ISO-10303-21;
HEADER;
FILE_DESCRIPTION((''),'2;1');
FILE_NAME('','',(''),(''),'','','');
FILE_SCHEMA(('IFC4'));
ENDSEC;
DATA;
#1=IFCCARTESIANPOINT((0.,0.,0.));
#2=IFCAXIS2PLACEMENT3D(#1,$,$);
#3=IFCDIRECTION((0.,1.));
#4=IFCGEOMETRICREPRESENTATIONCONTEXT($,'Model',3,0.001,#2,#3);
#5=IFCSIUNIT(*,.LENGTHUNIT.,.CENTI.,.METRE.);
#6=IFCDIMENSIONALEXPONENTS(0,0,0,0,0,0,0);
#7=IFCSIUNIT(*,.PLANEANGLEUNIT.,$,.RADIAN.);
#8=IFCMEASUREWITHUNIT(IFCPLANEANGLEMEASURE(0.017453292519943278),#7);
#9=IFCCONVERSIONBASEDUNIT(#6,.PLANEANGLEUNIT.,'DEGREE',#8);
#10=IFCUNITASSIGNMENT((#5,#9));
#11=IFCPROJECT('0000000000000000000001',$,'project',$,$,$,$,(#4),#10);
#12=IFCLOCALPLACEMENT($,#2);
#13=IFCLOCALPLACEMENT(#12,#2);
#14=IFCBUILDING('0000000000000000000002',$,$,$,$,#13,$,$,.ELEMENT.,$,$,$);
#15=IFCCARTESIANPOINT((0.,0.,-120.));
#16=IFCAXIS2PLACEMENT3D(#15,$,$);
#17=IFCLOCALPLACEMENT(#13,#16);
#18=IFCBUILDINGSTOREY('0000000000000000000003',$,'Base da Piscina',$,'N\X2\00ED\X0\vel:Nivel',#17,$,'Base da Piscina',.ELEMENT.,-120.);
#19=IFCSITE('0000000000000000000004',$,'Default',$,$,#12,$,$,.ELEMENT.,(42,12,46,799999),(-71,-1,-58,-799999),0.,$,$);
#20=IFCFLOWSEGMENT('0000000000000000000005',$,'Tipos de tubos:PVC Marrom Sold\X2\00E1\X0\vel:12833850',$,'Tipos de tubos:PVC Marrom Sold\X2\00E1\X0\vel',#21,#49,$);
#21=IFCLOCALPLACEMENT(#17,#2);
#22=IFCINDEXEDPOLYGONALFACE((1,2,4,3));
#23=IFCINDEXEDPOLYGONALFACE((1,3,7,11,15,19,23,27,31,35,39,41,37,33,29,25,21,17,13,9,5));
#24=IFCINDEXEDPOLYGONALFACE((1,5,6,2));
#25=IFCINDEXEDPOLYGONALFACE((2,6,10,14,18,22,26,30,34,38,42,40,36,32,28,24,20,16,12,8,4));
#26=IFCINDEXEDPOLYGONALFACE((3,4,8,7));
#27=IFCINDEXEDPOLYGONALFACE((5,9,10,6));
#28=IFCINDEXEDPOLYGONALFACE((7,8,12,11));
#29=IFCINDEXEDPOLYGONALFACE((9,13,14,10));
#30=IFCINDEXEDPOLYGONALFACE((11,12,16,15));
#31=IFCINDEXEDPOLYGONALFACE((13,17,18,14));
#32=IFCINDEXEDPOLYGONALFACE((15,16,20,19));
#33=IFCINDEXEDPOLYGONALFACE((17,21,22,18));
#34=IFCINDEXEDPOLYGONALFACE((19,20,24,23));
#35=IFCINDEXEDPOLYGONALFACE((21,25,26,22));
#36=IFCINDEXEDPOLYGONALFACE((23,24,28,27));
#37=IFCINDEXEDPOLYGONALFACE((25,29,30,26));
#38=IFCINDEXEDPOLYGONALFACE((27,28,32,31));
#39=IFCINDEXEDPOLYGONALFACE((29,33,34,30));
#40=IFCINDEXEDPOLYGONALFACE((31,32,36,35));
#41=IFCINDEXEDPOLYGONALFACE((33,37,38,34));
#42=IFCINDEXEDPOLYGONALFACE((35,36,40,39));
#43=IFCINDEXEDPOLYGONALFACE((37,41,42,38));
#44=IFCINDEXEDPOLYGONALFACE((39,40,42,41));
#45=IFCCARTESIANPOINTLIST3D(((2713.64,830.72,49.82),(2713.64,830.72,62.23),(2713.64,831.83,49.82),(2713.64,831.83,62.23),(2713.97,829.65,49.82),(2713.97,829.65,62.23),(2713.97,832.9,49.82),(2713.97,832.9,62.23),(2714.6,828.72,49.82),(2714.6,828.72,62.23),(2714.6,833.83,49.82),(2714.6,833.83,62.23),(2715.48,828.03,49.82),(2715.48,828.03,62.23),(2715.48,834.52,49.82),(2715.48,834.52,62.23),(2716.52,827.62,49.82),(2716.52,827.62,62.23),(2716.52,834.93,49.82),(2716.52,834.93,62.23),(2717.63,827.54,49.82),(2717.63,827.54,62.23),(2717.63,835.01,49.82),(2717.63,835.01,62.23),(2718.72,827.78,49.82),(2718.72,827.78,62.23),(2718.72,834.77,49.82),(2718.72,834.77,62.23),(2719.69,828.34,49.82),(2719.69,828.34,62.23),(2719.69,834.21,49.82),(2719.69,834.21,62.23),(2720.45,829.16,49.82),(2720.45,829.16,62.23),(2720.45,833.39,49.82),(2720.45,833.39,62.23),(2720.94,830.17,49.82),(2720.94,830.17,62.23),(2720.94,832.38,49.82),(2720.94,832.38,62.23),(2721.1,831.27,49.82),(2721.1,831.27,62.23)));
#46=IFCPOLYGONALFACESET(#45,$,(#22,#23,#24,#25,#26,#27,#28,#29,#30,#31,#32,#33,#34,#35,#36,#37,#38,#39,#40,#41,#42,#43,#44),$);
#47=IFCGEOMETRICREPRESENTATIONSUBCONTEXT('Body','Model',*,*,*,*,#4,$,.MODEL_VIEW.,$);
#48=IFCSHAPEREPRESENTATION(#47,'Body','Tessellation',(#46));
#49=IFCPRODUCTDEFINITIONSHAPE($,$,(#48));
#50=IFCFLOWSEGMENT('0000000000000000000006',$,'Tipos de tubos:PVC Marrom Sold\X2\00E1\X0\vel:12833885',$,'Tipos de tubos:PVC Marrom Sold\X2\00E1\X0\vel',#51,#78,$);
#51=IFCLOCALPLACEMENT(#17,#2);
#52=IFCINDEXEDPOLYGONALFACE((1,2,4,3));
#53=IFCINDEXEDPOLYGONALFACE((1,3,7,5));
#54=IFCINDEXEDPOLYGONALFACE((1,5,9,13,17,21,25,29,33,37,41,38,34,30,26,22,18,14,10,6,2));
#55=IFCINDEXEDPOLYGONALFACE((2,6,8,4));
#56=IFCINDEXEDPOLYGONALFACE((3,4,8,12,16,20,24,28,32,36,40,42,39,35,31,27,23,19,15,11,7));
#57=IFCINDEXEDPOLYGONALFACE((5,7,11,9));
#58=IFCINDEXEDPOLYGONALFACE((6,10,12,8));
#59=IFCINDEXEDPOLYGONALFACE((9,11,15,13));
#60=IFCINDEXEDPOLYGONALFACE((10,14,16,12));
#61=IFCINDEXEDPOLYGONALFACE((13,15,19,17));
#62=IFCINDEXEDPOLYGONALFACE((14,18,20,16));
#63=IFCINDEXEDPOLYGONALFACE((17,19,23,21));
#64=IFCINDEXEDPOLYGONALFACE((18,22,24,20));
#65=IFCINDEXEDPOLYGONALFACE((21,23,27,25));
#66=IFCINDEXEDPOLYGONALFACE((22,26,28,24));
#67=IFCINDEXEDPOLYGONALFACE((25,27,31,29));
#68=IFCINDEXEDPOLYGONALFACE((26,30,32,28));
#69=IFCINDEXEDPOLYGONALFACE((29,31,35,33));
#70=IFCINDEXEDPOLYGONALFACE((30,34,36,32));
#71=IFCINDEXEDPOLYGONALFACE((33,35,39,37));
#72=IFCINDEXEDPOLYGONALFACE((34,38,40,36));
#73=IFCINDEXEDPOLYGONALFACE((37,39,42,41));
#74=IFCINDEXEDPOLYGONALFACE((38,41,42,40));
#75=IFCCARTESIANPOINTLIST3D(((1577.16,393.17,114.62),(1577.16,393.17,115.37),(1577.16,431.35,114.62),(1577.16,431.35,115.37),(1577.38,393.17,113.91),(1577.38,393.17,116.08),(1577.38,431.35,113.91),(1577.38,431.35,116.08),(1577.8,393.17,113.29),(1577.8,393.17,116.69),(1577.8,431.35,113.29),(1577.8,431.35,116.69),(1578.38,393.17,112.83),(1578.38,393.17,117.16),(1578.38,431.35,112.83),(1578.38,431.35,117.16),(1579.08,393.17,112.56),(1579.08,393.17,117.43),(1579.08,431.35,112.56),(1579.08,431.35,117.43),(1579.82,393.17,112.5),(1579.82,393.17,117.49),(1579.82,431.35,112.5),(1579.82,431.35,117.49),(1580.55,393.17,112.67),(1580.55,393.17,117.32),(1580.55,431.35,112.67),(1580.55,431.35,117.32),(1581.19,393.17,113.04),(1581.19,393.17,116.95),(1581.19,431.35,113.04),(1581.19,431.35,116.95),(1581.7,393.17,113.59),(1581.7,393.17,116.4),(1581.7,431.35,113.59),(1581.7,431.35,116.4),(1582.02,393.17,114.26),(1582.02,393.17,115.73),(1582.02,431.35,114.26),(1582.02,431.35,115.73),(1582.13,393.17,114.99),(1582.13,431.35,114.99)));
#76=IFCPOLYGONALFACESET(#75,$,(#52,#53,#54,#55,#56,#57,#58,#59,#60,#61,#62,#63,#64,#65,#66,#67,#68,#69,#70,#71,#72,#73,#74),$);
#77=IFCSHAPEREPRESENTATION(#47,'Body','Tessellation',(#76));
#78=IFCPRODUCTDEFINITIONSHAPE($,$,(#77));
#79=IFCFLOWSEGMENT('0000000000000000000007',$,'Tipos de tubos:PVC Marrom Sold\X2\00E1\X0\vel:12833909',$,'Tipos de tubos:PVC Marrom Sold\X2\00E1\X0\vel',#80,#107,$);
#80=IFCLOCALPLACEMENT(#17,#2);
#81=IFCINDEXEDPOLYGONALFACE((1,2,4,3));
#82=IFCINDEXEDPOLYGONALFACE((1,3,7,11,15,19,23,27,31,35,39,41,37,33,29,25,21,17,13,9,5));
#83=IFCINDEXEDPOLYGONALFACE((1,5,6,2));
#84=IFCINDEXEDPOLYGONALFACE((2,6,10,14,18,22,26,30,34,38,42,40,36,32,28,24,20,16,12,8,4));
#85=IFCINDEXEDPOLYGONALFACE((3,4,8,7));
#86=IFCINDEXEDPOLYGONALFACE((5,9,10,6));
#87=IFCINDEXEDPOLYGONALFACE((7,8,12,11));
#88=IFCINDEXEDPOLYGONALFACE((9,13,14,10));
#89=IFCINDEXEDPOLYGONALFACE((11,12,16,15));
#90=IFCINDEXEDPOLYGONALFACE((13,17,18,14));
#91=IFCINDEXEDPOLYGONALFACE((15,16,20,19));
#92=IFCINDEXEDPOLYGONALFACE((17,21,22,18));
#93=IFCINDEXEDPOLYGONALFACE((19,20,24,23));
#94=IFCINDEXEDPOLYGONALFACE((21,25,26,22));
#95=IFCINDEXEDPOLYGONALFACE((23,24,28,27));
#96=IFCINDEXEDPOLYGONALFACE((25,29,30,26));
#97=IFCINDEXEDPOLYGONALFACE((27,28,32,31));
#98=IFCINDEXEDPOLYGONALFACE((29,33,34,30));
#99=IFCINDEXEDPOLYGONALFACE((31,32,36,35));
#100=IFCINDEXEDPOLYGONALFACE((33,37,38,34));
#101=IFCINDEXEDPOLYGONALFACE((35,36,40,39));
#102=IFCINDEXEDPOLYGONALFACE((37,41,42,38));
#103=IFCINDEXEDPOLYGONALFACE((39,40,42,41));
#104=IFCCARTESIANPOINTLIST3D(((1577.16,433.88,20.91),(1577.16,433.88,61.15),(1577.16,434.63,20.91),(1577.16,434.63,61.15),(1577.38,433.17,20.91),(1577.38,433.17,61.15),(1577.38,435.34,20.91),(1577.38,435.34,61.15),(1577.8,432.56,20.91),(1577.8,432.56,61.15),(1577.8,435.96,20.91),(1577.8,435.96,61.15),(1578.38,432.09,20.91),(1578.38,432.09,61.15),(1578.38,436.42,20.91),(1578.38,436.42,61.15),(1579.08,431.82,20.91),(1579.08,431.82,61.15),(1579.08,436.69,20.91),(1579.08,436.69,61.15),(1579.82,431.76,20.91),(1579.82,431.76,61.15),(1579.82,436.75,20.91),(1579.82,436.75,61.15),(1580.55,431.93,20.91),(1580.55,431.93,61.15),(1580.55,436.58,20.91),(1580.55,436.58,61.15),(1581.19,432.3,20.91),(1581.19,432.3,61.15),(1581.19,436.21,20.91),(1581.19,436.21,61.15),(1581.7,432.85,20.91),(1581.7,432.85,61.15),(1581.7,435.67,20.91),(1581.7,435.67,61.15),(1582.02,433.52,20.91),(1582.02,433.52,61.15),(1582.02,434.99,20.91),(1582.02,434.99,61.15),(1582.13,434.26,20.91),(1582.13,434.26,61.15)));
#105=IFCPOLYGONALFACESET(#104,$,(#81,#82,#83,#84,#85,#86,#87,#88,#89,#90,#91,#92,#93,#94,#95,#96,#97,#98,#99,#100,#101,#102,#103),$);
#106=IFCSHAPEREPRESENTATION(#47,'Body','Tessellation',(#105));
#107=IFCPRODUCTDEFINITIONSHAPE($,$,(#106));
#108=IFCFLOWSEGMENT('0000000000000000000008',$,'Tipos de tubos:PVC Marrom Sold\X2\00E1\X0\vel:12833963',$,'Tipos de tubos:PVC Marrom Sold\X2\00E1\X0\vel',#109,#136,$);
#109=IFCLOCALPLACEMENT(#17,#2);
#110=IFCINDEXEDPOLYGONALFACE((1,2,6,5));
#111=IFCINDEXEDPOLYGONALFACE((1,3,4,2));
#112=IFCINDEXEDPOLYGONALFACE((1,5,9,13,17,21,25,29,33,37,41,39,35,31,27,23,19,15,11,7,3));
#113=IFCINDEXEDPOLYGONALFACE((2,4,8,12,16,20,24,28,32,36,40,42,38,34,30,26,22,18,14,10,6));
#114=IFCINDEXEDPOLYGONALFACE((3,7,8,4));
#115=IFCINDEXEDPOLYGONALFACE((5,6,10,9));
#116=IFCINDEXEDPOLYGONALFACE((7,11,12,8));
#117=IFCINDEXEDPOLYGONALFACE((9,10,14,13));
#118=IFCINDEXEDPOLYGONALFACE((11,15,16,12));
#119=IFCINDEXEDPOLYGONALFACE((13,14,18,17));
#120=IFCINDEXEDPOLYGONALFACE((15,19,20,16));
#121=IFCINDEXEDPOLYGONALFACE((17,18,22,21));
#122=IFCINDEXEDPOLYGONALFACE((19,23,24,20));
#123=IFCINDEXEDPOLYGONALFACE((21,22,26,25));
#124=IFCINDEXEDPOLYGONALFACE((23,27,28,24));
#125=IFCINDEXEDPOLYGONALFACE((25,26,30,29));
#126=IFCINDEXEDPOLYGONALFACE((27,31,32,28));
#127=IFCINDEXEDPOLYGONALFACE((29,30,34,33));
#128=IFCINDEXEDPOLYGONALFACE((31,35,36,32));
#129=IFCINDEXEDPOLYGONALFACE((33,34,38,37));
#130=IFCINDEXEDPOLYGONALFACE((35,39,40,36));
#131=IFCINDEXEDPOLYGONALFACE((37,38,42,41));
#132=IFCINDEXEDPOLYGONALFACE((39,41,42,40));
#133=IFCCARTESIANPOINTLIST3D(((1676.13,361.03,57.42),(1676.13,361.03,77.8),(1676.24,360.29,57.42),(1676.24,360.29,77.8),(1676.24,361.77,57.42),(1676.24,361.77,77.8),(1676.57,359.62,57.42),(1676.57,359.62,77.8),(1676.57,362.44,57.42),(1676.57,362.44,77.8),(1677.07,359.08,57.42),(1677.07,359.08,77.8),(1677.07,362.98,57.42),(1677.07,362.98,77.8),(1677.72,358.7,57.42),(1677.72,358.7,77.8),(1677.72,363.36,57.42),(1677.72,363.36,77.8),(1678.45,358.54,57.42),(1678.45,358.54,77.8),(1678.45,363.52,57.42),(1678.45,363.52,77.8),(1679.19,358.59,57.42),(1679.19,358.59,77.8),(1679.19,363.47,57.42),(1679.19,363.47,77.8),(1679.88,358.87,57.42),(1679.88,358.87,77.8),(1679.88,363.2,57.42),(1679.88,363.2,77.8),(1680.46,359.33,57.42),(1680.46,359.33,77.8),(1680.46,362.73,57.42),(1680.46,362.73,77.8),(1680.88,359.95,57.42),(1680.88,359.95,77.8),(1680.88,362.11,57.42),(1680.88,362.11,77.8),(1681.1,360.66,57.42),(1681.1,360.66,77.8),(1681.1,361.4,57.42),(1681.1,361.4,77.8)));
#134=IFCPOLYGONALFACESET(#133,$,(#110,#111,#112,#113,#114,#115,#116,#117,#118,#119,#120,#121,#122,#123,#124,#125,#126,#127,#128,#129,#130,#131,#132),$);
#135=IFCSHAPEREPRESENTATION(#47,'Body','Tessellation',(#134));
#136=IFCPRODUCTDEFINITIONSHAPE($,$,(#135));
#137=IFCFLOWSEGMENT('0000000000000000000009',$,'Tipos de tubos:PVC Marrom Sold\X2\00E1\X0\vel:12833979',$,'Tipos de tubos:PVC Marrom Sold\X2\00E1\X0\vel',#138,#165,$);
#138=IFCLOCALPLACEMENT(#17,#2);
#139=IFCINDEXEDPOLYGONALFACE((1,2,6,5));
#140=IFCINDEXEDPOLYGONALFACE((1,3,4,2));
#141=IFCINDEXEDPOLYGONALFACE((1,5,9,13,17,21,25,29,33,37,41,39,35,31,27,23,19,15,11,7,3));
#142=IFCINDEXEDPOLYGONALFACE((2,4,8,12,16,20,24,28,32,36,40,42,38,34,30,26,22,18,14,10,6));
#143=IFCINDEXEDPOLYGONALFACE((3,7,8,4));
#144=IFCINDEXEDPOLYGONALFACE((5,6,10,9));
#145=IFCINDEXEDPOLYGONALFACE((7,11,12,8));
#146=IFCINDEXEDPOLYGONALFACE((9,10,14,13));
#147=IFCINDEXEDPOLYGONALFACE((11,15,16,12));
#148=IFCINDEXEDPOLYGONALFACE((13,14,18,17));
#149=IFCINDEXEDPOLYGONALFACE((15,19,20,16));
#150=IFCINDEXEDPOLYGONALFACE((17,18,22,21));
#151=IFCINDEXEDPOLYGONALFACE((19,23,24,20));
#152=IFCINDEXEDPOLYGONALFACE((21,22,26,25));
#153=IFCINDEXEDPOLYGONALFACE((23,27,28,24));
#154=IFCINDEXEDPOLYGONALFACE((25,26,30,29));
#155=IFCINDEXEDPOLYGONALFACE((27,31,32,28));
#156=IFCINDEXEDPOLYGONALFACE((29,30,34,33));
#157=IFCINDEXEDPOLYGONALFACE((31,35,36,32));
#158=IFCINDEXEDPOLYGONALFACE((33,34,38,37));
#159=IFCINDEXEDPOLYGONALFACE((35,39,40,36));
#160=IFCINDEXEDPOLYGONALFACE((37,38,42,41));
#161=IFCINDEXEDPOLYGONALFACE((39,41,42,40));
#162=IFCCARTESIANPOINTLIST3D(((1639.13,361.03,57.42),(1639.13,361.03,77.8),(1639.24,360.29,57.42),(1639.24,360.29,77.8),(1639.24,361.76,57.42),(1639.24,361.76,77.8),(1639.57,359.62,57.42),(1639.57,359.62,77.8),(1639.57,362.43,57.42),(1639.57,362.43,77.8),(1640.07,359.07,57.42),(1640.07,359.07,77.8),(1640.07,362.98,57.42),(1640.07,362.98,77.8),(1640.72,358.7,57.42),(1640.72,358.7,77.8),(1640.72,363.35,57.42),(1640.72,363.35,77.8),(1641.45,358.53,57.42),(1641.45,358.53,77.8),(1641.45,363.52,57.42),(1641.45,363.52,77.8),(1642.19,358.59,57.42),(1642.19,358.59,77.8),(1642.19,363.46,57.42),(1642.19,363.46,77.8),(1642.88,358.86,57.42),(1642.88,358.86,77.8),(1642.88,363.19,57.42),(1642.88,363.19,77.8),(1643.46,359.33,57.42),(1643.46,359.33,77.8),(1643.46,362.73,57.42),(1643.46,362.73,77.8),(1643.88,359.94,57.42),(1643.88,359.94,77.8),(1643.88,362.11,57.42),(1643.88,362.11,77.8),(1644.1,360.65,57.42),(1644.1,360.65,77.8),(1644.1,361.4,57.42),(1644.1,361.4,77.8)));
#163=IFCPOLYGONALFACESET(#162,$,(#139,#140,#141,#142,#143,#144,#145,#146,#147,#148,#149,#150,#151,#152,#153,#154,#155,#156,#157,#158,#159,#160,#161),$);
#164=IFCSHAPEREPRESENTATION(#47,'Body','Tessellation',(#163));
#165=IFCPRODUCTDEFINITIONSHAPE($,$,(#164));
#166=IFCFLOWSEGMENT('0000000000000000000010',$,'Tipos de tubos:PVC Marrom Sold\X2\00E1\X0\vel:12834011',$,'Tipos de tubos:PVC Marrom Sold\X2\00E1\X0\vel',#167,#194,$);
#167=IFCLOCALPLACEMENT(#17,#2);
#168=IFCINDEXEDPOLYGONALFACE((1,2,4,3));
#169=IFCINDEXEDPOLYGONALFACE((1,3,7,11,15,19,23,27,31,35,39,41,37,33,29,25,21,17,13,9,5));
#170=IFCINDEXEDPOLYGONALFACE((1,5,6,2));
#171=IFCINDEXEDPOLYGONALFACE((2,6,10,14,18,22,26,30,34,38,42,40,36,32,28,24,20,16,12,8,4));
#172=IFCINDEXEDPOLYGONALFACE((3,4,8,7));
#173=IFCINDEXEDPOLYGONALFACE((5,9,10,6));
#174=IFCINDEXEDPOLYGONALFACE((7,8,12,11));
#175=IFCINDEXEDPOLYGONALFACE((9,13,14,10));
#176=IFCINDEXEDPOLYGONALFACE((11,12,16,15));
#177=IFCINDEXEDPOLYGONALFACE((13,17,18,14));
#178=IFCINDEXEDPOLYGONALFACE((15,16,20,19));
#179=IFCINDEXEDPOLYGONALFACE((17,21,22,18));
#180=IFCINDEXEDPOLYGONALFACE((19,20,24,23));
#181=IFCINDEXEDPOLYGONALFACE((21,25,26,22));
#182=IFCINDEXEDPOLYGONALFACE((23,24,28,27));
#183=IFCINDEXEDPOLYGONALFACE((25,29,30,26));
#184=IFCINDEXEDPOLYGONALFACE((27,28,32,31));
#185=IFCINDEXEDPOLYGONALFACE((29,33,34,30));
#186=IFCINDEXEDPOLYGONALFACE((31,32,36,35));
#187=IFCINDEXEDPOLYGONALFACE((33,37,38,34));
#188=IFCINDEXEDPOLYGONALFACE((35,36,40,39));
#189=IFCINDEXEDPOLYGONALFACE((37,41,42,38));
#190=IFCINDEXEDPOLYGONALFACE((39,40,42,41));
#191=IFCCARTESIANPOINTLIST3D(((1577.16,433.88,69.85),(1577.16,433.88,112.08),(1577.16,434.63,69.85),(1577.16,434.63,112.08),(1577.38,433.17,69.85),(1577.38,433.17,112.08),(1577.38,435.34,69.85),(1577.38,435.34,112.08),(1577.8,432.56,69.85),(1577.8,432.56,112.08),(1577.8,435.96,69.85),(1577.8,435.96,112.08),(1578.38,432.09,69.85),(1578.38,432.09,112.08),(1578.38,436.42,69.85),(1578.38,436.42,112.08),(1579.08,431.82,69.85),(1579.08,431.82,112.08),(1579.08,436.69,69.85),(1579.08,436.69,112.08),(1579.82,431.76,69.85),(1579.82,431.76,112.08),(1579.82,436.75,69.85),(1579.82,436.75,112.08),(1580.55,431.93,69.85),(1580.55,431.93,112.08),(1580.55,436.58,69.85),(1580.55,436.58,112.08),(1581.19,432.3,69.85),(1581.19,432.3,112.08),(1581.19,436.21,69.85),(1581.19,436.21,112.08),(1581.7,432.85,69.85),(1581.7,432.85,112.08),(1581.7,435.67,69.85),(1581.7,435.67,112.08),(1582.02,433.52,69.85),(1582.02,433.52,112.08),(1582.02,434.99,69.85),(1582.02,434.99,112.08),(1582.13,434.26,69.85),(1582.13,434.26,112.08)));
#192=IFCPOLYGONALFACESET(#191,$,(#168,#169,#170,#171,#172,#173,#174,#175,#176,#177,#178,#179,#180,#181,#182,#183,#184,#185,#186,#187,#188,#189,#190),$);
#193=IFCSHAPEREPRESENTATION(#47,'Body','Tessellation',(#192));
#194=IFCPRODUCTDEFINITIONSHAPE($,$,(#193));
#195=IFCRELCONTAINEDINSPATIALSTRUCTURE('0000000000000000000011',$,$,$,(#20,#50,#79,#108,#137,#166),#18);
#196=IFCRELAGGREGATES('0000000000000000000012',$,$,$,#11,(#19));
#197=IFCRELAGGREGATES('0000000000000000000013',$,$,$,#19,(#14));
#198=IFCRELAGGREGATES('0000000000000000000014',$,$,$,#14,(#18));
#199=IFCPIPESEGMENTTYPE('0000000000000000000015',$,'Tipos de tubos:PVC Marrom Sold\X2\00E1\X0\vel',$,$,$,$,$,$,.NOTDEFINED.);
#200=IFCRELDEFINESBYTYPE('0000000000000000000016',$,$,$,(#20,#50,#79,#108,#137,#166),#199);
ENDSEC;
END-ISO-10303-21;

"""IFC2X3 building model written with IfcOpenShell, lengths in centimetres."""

from ifc_helpers import new_model, entity, si_unit, converted_unit, direction, frame, frame_2d, origin, origin_2d_with_axis, place, context, subcontext, project, spatial, circle, extrude, type_object, element, save


model = new_model("IFC2X3")

# Units and contexts
model_context = context("Model", 3, precision=0.001, world=origin(), true_north=direction((0.0, 1.0)))
body_context = subcontext(model_context, "Body", "Model", "MODEL_VIEW")
ifc_project = project(units=[si_unit("LENGTHUNIT", "METRE", prefix="CENTI"), converted_unit("PLANEANGLEUNIT", "DEGREE", entity("IfcPlaneAngleMeasure", 0.017453292519943278), si_unit("PLANEANGLEUNIT", "RADIAN"), dimensions=[0, 0, 0, 0, 0, 0, 0])], contexts=[model_context])

# Site, building, storey
site_placement = place(None, origin())
site = spatial("IfcSite", under=ifc_project, at=site_placement, Name="Default", CompositionType="ELEMENT", RefLatitude=(42, 12, 46, 799999), RefLongitude=(-71, -1, -58, -799999), RefElevation=0.0)
building_placement = place(site_placement, origin())
building = spatial("IfcBuilding", under=site, at=building_placement, CompositionType="ELEMENT")
storey_placement = place(building_placement, frame((0.0, 0.0, -120.0)))
storey = spatial("IfcBuildingStorey", under=building, at=storey_placement, Name="Base da Piscina", ObjectType="Nível:Nivel", LongName="Base da Piscina", CompositionType="ELEMENT", Elevation=-120.0)

# Flow segments
pipe_segment_type = type_object("IfcPipeSegmentType", Name="Tipos de tubos:PVC Marrom Soldável", PredefinedType="NOTDEFINED")
flow_segment_1_placement = place(storey_placement, origin())
element("IfcFlowSegment", 1, at=flow_segment_1_placement, inside=storey, type_object=pipe_segment_type, Name="Tipos de tubos:PVC Marrom Soldável:12833850", ObjectType="Tipos de tubos:PVC Marrom Soldável", context=body_context, shape_type="SweptSolid", body=[
    extrude(circle(Radius=3.75, at=origin_2d_with_axis()), frame((2717.35, 831.27, 49.82)), (0.0, 0.0, 1.0), 12.41),
])
flow_segment_2_placement = place(storey_placement, origin())
element("IfcFlowSegment", 2, at=flow_segment_2_placement, inside=storey, type_object=pipe_segment_type, Name="Tipos de tubos:PVC Marrom Soldável:12833885", ObjectType="Tipos de tubos:PVC Marrom Soldável", context=body_context, shape_type="SweptSolid", body=[
    extrude(circle(Radius=2.5, at=frame_2d((0.0, 0.0), x_axis=(1.0, 0.0))), frame((1579.63, 393.17, 114.99), z_axis=(0.0, 1.0, 0.0), x_axis=(1.0, 0.0, 0.0)), (0.0, 0.0, 1.0), 38.17),
])
flow_segment_3_placement = place(storey_placement, origin())
element("IfcFlowSegment", 3, at=flow_segment_3_placement, inside=storey, type_object=pipe_segment_type, Name="Tipos de tubos:PVC Marrom Soldável:12833909", ObjectType="Tipos de tubos:PVC Marrom Soldável", context=body_context, shape_type="SweptSolid", body=[
    extrude(circle(Radius=2.5, at=frame_2d((0.0, 0.0), x_axis=(1.0, 0.0))), frame((1579.63, 434.26, 20.91)), (0.0, 0.0, 1.0), 40.24),
])
flow_segment_4_placement = place(storey_placement, origin())
element("IfcFlowSegment", 4, at=flow_segment_4_placement, inside=storey, type_object=pipe_segment_type, Name="Tipos de tubos:PVC Marrom Soldável:12833963", ObjectType="Tipos de tubos:PVC Marrom Soldável", context=body_context, shape_type="SweptSolid", body=[
    extrude(circle(Radius=2.5, at=frame_2d((0.0, 0.0), x_axis=(1.0, 0.0))), frame((1678.63, 361.03, 57.42), z_axis=(0.0, 0.0, 1.0), x_axis=(-1.0, 0.0, 0.0)), (0.0, 0.0, 1.0), 20.38),
])
flow_segment_5_placement = place(storey_placement, origin())
element("IfcFlowSegment", 5, at=flow_segment_5_placement, inside=storey, type_object=pipe_segment_type, Name="Tipos de tubos:PVC Marrom Soldável:12833979", ObjectType="Tipos de tubos:PVC Marrom Soldável", context=body_context, shape_type="SweptSolid", body=[
    extrude(circle(Radius=2.5, at=origin_2d_with_axis()), frame((1641.63, 361.03, 57.42), z_axis=(0.0, 0.0, 1.0), x_axis=(-1.0, 0.0, 0.0)), (0.0, 0.0, 1.0), 20.38),
])
flow_segment_6_placement = place(storey_placement, origin())
element("IfcFlowSegment", 6, at=flow_segment_6_placement, inside=storey, type_object=pipe_segment_type, Name="Tipos de tubos:PVC Marrom Soldável:12834011", ObjectType="Tipos de tubos:PVC Marrom Soldável", context=body_context, shape_type="SweptSolid", body=[
    extrude(circle(Radius=2.5, at=frame_2d((0.0, 0.0), x_axis=(1.0, 0.0))), frame((1579.63, 434.26, 69.85)), (0.0, 0.0, 1.0), 42.24),
])

save(model, "model.ifc")
